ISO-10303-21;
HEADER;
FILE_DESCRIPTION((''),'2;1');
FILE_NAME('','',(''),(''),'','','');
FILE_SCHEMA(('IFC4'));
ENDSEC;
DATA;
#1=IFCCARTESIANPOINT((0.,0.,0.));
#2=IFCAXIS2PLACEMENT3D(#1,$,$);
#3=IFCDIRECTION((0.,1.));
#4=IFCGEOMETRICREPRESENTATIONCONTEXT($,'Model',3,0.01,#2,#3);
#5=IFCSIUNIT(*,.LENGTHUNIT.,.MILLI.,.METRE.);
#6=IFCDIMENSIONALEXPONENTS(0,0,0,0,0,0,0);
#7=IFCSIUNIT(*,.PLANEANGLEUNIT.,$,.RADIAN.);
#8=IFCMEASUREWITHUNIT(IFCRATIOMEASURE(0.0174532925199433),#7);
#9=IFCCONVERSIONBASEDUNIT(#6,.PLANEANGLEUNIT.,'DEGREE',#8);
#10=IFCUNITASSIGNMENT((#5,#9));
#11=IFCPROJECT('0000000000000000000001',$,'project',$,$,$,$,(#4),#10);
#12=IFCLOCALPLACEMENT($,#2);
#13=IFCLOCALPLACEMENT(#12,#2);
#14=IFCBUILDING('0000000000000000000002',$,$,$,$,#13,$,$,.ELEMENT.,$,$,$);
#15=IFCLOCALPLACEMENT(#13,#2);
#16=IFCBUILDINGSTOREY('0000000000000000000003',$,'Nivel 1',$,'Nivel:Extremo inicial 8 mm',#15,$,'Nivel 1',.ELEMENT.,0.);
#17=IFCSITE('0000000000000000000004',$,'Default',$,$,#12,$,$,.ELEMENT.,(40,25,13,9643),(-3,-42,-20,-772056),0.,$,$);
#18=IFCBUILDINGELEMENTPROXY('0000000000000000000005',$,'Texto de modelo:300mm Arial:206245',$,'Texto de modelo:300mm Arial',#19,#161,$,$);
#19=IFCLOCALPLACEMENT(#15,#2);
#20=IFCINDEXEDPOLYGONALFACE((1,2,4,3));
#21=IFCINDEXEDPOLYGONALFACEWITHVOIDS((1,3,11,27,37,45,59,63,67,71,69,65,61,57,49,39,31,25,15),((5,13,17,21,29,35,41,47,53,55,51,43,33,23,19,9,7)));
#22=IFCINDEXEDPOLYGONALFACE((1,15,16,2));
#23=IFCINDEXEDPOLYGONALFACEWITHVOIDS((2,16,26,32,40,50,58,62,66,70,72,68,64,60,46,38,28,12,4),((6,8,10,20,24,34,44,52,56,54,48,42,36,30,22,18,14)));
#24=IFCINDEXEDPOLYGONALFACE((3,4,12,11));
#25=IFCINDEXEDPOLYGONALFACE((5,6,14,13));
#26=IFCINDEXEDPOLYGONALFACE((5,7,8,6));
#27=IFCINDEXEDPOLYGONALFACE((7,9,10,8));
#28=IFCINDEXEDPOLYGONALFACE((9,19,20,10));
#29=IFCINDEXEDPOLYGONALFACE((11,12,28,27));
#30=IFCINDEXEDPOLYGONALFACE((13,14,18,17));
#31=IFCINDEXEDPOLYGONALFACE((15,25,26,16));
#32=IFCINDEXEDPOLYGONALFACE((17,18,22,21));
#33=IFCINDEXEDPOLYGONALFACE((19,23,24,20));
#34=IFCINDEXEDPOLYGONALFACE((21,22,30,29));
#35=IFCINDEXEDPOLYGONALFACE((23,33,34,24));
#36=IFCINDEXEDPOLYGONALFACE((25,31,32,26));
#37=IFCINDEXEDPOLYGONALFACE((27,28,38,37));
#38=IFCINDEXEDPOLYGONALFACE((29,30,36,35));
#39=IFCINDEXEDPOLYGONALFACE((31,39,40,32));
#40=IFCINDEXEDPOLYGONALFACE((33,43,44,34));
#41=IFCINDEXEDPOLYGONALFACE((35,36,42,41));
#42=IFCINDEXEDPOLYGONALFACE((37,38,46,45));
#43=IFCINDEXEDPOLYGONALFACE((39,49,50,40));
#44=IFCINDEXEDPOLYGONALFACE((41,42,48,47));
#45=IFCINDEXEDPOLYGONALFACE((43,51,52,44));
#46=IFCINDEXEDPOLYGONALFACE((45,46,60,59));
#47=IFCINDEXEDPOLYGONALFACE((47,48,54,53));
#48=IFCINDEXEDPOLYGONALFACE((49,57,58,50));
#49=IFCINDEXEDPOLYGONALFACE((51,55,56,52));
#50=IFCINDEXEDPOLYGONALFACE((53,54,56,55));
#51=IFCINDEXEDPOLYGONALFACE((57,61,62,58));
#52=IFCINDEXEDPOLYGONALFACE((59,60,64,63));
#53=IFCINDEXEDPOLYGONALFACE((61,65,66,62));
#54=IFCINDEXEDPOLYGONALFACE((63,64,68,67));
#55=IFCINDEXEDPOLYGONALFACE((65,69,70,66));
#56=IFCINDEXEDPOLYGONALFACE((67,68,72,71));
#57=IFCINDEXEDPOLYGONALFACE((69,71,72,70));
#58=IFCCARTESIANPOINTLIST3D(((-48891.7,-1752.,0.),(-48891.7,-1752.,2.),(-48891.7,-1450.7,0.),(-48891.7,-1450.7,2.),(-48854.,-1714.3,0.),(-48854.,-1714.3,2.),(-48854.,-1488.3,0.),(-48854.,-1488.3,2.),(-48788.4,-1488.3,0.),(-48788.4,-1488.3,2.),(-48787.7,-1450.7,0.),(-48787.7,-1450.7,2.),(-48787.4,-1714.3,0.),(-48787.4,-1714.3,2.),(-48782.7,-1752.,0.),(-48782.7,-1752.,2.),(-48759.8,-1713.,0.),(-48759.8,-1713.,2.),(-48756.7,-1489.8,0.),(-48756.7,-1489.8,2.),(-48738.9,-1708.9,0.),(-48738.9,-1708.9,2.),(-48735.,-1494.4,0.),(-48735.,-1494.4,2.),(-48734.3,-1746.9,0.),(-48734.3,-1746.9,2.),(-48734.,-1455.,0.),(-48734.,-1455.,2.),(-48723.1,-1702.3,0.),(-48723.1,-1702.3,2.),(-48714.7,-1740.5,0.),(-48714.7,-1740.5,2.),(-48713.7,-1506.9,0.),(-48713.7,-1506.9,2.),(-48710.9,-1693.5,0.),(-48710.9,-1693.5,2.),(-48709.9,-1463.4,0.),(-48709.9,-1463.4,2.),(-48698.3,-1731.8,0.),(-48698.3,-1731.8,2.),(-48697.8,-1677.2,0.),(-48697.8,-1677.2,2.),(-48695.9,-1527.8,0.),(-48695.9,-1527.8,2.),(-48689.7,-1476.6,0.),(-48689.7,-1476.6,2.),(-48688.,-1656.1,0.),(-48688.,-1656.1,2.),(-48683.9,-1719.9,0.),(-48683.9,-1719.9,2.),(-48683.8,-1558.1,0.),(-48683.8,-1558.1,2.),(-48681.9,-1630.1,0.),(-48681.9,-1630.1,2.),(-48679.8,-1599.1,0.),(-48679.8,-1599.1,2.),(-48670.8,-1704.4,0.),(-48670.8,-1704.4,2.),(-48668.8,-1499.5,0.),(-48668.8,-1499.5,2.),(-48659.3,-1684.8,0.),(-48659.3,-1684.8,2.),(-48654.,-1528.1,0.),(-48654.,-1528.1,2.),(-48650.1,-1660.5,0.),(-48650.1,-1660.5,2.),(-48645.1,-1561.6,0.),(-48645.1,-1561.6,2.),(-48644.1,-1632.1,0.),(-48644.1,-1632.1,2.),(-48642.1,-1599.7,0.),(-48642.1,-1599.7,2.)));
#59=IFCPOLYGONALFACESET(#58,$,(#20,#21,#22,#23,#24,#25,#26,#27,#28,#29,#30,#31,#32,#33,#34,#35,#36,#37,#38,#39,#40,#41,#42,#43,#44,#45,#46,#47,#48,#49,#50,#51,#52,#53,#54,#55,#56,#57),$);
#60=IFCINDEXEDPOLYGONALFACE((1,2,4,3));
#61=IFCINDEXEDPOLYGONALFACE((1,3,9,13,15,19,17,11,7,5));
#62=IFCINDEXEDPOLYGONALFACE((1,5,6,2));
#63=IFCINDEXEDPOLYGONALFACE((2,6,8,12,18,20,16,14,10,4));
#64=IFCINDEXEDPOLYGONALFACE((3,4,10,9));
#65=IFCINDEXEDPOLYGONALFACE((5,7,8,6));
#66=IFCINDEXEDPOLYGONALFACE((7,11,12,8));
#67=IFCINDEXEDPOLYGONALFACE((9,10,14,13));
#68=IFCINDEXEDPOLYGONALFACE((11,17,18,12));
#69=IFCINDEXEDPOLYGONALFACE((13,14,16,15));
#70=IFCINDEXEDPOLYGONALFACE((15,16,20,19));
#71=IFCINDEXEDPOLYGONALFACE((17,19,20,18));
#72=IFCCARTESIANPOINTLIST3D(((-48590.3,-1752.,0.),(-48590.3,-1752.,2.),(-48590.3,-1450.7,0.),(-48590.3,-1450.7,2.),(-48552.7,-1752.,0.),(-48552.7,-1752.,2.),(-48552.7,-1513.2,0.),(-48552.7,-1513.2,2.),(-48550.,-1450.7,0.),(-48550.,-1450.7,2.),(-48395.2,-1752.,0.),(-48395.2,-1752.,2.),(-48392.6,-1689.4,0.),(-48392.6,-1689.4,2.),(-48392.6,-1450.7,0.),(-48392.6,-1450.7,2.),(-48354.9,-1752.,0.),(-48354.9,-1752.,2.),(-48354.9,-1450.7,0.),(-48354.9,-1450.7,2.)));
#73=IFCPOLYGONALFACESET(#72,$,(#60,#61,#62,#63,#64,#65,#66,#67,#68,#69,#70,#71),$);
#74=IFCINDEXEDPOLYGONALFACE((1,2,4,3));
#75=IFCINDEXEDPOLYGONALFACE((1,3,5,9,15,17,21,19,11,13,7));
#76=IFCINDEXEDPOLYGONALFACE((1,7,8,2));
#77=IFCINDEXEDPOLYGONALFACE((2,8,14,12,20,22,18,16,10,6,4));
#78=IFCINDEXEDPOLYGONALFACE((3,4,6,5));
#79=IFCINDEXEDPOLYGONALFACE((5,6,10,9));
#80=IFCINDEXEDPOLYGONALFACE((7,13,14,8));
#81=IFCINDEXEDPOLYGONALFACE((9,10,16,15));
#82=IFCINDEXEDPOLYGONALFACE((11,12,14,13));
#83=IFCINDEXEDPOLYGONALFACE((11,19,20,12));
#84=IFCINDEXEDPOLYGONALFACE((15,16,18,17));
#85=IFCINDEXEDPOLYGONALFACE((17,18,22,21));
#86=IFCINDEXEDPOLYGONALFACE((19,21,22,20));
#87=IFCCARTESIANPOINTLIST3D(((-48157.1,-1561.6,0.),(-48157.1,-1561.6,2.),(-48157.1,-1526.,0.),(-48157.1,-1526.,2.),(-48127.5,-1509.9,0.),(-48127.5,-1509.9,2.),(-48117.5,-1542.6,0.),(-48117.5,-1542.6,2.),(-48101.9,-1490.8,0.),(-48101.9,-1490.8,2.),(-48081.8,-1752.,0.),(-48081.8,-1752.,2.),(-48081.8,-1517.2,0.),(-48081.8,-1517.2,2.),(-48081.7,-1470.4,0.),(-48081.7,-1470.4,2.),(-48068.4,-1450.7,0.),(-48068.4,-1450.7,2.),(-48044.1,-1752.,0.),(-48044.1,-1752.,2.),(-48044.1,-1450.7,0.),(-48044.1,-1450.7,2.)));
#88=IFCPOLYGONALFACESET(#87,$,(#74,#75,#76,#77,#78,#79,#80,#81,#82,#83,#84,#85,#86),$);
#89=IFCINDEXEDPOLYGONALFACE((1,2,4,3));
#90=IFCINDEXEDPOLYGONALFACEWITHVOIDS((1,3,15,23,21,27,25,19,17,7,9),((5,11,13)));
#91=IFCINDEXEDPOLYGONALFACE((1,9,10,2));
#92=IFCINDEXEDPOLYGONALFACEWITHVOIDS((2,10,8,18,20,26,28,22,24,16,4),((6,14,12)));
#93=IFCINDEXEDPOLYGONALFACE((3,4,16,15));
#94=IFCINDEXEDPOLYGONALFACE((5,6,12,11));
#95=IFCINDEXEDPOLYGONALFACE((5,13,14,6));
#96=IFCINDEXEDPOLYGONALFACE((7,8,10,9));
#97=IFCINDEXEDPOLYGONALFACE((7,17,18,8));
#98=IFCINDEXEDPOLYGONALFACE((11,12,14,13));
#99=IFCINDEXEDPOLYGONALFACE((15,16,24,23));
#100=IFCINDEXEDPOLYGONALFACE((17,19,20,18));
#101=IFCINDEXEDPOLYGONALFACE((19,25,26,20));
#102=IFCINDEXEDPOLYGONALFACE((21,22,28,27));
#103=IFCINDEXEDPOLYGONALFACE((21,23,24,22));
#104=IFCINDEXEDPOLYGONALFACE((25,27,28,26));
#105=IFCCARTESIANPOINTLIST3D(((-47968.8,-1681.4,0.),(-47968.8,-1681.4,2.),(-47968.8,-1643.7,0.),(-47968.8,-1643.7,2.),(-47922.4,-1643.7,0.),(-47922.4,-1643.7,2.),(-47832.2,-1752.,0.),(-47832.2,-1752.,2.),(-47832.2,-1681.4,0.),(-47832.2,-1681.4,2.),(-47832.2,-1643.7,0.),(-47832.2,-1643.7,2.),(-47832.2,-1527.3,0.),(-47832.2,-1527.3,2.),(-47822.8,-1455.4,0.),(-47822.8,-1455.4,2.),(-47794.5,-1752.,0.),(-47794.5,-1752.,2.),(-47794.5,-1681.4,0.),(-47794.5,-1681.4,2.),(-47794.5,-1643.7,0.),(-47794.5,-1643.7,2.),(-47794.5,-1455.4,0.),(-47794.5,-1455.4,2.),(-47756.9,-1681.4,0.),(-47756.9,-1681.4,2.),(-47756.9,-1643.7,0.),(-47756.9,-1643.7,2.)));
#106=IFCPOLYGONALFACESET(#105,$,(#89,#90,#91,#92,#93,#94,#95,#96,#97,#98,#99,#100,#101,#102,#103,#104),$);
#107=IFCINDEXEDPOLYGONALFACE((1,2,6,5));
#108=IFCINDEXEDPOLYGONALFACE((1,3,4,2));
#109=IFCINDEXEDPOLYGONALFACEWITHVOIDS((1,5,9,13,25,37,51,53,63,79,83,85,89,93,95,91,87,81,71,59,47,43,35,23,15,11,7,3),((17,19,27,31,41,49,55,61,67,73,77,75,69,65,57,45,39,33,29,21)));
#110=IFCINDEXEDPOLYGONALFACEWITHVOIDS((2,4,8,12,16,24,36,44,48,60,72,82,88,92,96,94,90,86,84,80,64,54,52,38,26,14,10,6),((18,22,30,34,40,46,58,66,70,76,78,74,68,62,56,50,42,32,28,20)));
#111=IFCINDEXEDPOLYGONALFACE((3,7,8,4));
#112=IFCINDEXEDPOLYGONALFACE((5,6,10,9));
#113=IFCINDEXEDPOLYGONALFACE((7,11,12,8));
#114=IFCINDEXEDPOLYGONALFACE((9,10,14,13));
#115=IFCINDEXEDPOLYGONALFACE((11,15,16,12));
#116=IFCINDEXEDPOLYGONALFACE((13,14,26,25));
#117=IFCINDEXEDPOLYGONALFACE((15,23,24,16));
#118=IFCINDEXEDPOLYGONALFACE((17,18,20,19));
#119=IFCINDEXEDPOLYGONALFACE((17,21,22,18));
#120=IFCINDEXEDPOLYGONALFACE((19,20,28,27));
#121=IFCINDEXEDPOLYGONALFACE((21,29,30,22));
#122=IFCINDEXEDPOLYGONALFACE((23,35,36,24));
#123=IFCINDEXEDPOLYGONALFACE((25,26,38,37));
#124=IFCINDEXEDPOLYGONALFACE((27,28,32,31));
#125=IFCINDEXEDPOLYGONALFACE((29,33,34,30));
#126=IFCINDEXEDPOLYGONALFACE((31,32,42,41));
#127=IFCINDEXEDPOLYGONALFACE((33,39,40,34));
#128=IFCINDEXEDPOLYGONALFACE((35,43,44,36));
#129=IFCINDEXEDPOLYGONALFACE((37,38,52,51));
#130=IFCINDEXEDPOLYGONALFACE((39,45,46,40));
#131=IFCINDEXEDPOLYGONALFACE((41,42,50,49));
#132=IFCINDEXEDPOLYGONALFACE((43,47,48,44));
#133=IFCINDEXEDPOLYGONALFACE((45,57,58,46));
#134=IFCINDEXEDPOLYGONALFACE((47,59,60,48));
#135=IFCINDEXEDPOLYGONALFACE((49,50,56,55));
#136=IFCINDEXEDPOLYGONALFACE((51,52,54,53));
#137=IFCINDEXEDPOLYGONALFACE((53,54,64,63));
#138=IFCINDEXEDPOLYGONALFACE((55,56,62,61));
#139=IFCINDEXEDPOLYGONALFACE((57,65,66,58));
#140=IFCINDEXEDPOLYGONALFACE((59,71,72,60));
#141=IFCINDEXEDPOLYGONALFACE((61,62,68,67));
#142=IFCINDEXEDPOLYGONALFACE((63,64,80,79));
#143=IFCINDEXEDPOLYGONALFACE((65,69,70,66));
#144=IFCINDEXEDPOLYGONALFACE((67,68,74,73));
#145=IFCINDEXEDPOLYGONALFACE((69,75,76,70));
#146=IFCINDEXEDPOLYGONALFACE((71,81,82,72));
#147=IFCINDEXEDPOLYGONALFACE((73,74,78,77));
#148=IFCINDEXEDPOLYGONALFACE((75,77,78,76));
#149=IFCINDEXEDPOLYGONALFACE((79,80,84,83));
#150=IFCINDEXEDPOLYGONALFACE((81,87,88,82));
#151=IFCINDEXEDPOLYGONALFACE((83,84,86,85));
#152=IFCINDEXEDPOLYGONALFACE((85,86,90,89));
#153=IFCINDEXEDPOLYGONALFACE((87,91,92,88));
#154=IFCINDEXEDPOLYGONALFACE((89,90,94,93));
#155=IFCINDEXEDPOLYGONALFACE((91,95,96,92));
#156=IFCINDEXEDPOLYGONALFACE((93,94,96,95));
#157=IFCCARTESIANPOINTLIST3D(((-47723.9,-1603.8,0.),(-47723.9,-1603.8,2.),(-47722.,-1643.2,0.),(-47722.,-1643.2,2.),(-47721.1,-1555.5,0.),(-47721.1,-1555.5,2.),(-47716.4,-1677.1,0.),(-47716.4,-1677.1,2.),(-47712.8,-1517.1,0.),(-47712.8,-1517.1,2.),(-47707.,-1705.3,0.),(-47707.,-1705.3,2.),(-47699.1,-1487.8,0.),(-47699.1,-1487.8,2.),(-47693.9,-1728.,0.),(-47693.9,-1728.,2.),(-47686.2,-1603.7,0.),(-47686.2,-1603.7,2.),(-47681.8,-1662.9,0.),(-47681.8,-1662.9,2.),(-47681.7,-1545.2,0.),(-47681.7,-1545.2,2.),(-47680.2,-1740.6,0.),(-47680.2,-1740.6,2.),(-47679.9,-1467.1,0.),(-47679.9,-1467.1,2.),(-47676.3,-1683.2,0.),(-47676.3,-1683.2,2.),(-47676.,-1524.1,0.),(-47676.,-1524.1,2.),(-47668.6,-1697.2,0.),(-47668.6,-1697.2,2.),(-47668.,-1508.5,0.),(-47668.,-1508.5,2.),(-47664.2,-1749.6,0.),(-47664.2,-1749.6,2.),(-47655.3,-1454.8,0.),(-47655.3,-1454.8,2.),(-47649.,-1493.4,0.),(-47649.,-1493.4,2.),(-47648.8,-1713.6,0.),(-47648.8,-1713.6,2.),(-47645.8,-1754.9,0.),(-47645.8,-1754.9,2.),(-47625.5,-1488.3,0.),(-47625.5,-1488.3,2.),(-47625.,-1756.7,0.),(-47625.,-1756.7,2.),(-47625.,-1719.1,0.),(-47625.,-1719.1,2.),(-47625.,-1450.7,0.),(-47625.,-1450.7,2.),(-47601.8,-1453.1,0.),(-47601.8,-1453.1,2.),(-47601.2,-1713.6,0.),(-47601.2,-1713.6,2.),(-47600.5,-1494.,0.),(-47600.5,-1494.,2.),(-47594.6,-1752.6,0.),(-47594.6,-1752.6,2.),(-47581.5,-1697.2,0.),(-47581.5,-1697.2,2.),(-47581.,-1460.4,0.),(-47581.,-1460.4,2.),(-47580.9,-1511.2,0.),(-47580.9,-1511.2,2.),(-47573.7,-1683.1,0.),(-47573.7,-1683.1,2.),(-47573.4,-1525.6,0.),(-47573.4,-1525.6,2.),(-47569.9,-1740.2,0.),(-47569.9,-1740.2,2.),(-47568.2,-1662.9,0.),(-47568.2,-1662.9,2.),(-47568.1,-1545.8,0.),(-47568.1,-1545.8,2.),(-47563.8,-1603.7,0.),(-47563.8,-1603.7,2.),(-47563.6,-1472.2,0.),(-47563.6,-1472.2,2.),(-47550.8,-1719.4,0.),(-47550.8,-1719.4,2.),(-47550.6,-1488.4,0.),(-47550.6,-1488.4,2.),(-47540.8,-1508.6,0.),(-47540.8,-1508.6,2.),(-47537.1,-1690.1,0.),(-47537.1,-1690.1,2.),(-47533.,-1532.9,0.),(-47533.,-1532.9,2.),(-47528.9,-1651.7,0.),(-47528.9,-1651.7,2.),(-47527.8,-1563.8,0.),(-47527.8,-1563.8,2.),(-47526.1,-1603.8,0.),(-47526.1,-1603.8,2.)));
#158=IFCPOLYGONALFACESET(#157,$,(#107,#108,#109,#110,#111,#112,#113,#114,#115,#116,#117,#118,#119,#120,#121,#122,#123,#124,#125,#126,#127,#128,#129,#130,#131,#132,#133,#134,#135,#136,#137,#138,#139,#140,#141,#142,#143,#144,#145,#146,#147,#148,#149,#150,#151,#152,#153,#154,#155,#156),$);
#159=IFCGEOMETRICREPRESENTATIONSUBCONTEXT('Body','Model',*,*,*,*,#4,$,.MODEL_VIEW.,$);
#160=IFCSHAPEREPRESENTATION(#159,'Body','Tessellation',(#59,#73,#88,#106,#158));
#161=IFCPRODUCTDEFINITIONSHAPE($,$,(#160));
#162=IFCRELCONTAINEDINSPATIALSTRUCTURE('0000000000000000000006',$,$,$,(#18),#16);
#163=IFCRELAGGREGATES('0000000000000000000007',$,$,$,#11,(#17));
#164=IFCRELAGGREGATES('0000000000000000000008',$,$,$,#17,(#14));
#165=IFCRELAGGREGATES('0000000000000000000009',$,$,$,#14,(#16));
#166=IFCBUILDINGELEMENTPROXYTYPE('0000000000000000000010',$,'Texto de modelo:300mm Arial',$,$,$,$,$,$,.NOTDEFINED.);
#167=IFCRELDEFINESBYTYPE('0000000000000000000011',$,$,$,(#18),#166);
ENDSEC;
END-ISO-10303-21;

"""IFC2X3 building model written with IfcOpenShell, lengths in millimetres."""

from ifc_helpers import new_model, entity, si_unit, converted_unit, direction, frame, origin, place, context, subcontext, project, spatial, polyline, outline, extrude, type_object, element, save


model = new_model("IFC2X3")

# Units and contexts
model_context = context("Model", 3, precision=0.01, world=origin(), true_north=direction((0.0, 1.0)))
body_context = subcontext(model_context, "Body", "Model", "MODEL_VIEW")
ifc_project = project(units=[si_unit("LENGTHUNIT", "METRE", prefix="MILLI"), converted_unit("PLANEANGLEUNIT", "DEGREE", entity("IfcRatioMeasure", 0.0174532925199433), si_unit("PLANEANGLEUNIT", "RADIAN"), dimensions=[0, 0, 0, 0, 0, 0, 0])], contexts=[model_context])

# Site, building, storey
site_placement = place(None, origin())
site = spatial("IfcSite", under=ifc_project, at=site_placement, Name="Default", CompositionType="ELEMENT", RefLatitude=(40, 25, 13, 9643), RefLongitude=(-3, -42, -20, -772056), RefElevation=0.0)
building_placement = place(site_placement, origin())
building = spatial("IfcBuilding", under=site, at=building_placement, CompositionType="ELEMENT")
storey_placement = place(building_placement, origin())
storey = spatial("IfcBuildingStorey", under=building, at=storey_placement, Name="Nivel 1", ObjectType="Nivel:Extremo inicial 8 mm", LongName="Nivel 1", CompositionType="ELEMENT", Elevation=0.0)

# Building element proxy
building_element_proxy_type_1 = type_object("IfcBuildingElementProxyType", Name="Texto de modelo:300mm Arial", PredefinedType="NOTDEFINED")
proxy_1_placement = place(storey_placement, frame((-48891.7, -1756.7, 0.0)))
element("IfcBuildingElementProxy", 1, at=proxy_1_placement, inside=storey, type_object=building_element_proxy_type_1, Name="Texto de modelo:300mm Arial:206245", ObjectType="Texto de modelo:300mm Arial", context=body_context, shape_type="SweptSolid", body=[
    extrude(outline(polyline([(-178.4, -141.0), (-69.4, -141.0), (-21.0, -135.8), (-1.4, -129.5), (15.0, -120.7), (29.4, -108.9), (42.6, -93.4), (54.0, -73.7), (63.2, -49.5), (69.2, -21.0), (71.2, 11.3), (68.2, 49.4), (59.3, 83.0), (44.5, 111.5), (23.7, 134.5), (3.4, 147.7), (-20.6, 156.1), (-74.4, 160.4), (-178.4, 160.4), (-178.4, -141.0)]), holes=[polyline([(-140.7, -103.3), (-140.7, 122.7), (-75.1, 122.7), (-43.3, 121.2), (-21.7, 116.7), (-0.4, 104.1), (17.4, 83.3), (29.5, 53.0), (33.5, 11.9), (31.5, -19.1), (25.3, -45.1), (15.5, -66.2), (2.4, -82.5), (-9.8, -91.3), (-25.6, -97.9), (-46.5, -101.9), (-74.1, -103.3), (-140.7, -103.3)])]), frame((178.4, 145.7, 0.0)), (0.0, 0.0, 1.0), 2.0),
    extrude(outline(polyline([(-117.7, -150.7), (-80.1, -150.7), (-80.1, 88.1), (77.4, -150.7), (117.7, -150.7), (117.7, 150.7), (80.1, 150.7), (80.1, -88.1), (-77.4, 150.7), (-117.7, 150.7), (-117.7, -150.7)])), frame((419.1, 155.4, 0.0)), (0.0, 0.0, 1.0), 2.0),
    extrude(outline(polyline([(-204.4, -52.5), (97.0, -52.5), (97.0, -28.2), (77.2, -14.9), (56.9, 5.3), (37.7, 30.9), (21.6, 60.5), (-14.0, 60.5), (5.0, 20.8), (30.4, -14.9), (-204.4, -14.9), (-204.4, -52.5)])), frame((795.1, 209.1, 0.0), z_axis=(0.0, 0.0, 1.0), x_axis=(0.0, 1.0, 0.0)), (0.0, 0.0, 1.0), 2.0),
    extrude(outline(polyline([(-3.4, -109.2), (34.2, -109.2), (34.2, -38.5), (71.9, -38.5), (71.9, -0.9), (34.2, -0.9), (34.2, 187.5), (6.0, 187.5), (-140.0, -0.9), (-140.0, -38.5), (-3.4, -38.5), (-3.4, -109.2)]), holes=[polyline([(-3.4, -0.9), (-93.6, -0.9), (-3.4, 115.5), (-3.4, -0.9)])]), frame((1062.9, 113.9, 0.0)), (0.0, 0.0, 1.0), 2.0),
    extrude(outline(polyline([(-5.6, -99.5), (33.9, -99.5), (68.0, -95.5), (96.7, -87.5), (120.0, -75.5), (133.2, -62.4), (142.9, -46.8), (149.1, -28.7), (151.9, -8.0), (149.2, 22.6), (138.0, 47.8), (118.2, 67.9), (89.5, 82.9), (51.6, 93.0), (3.8, 98.0), (-36.2, 98.2), (-67.3, 94.5), (-91.9, 87.9), (-112.6, 79.0), (-129.4, 66.8), (-142.0, 50.0), (-150.3, 29.6), (-153.8, 6.5), (-151.2, -23.9), (-140.1, -49.1), (-120.3, -69.2), (-91.7, -84.4), (-53.6, -94.5), (-5.6, -99.5)]), holes=[polyline([(-3.9, -61.9), (-62.1, -54.6), (-82.9, -47.9), (-98.1, -39.2), (-112.3, -19.5), (-116.2, 4.3), (-109.3, 28.9), (-91.2, 47.7), (-76.5, 54.5), (-56.1, 58.9), (1.9, 60.4), (60.8, 53.2), (80.8, 46.7), (94.5, 38.3), (109.9, 17.8), (114.3, -6.3), (107.7, -29.8), (90.4, -48.7), (76.0, -55.8), (55.5, -60.3), (-3.9, -61.9)])]), frame((1267.5, 152.1, 0.0), z_axis=(0.0, 0.0, 1.0), x_axis=(0.047515, -0.998871, 0.0)), (0.0, 0.0, 1.0), 2.0),
])

save(model, "model.ifc")
